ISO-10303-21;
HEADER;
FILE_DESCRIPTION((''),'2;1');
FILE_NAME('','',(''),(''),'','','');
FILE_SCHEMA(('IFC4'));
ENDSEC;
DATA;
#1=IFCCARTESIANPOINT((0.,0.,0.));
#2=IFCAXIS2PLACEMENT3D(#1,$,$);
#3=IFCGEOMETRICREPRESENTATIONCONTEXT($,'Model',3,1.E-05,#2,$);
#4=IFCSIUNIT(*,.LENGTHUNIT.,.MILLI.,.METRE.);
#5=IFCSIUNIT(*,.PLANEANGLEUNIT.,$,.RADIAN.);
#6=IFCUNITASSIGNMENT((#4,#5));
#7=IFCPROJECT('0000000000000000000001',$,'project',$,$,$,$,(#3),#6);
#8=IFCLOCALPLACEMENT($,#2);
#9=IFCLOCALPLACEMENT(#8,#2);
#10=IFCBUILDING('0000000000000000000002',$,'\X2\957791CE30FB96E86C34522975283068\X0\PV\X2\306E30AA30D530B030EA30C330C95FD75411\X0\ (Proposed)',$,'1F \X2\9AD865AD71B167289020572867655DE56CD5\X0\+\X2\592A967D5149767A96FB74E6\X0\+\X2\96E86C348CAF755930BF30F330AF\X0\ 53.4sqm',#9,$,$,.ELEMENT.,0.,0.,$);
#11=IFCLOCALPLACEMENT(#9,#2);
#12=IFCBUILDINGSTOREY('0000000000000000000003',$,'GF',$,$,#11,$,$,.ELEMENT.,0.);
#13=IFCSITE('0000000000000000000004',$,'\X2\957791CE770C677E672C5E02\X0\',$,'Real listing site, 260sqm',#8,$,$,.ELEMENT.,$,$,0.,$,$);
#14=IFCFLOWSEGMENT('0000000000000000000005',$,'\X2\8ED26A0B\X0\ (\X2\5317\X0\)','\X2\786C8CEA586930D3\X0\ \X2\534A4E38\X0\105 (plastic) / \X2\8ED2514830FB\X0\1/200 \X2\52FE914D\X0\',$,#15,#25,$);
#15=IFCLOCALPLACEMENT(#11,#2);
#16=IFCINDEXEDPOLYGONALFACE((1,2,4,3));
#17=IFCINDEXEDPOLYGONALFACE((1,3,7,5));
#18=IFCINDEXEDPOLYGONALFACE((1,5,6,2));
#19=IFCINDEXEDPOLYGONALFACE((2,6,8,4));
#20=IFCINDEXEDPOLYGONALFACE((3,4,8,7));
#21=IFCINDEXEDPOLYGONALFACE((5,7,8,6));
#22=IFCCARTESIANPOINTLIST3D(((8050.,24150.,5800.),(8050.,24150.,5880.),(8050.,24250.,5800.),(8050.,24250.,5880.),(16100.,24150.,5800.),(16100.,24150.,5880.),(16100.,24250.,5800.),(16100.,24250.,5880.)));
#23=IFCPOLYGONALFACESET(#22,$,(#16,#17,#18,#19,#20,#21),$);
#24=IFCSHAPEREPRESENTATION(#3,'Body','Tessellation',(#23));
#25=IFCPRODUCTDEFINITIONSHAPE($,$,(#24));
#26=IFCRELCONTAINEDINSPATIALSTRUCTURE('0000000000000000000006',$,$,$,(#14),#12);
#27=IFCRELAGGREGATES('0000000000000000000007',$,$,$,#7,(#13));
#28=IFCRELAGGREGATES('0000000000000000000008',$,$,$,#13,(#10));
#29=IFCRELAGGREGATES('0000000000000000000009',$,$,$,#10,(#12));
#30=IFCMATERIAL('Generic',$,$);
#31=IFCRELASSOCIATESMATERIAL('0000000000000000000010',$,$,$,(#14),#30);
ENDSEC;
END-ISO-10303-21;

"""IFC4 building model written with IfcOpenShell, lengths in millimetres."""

from ifc_helpers import new_model, si_unit, frame, frame_2d, origin, place, context, project, spatial, rectangle, extrude, material, element, save


model = new_model("IFC4")

# Units and contexts
model_context = context("Model", 3, precision=1e-05, world=origin())
ifc_project = project(units=[si_unit("LENGTHUNIT", "METRE", prefix="MILLI"), si_unit("PLANEANGLEUNIT", "RADIAN")], contexts=[model_context])

# Site, building, storey
site_placement = place(None, origin())
site = spatial("IfcSite", under=ifc_project, at=site_placement, Name="長野県松本市", ObjectType="Real listing site, 260sqm", CompositionType="ELEMENT", RefElevation=0.0)
building_placement = place(site_placement, origin())
building = spatial("IfcBuilding", under=site, at=building_placement, Name="長野・雨水利用とPVのオフグリッド志向 (Proposed)", ObjectType="1F 高断熱木造在来工法+太陽光発電瓦+雨水貯留タンク 53.4sqm", CompositionType="ELEMENT", ElevationOfRefHeight=0.0, ElevationOfTerrain=0.0)
storey_placement = place(building_placement, origin())
storey = spatial("IfcBuildingStorey", under=building, at=storey_placement, Name="GF", CompositionType="ELEMENT", Elevation=0.0)

# Shared definitions
ifc_material_1 = material(Name="Generic")

# Flow segment
flow_segment_1_placement = place(storey_placement, frame((4025.0, 12075.0, 2900.0)))
element("IfcFlowSegment", 1, at=flow_segment_1_placement, inside=storey, material=ifc_material_1, Name="軒樋 (北)", Description="硬質塩ビ 半丸105 (plastic) / 軒先・1/200 勾配", context=model_context, shape_type="SweptSolid", body=[
    extrude(rectangle(XDim=8050.0, YDim=100.0, at=frame_2d((4025.0, 50.0))), frame((4025.0, 12075.0, 2900.0)), (0.0, 0.0, 1.0), 80.0),
])

save(model, "model.ifc")
